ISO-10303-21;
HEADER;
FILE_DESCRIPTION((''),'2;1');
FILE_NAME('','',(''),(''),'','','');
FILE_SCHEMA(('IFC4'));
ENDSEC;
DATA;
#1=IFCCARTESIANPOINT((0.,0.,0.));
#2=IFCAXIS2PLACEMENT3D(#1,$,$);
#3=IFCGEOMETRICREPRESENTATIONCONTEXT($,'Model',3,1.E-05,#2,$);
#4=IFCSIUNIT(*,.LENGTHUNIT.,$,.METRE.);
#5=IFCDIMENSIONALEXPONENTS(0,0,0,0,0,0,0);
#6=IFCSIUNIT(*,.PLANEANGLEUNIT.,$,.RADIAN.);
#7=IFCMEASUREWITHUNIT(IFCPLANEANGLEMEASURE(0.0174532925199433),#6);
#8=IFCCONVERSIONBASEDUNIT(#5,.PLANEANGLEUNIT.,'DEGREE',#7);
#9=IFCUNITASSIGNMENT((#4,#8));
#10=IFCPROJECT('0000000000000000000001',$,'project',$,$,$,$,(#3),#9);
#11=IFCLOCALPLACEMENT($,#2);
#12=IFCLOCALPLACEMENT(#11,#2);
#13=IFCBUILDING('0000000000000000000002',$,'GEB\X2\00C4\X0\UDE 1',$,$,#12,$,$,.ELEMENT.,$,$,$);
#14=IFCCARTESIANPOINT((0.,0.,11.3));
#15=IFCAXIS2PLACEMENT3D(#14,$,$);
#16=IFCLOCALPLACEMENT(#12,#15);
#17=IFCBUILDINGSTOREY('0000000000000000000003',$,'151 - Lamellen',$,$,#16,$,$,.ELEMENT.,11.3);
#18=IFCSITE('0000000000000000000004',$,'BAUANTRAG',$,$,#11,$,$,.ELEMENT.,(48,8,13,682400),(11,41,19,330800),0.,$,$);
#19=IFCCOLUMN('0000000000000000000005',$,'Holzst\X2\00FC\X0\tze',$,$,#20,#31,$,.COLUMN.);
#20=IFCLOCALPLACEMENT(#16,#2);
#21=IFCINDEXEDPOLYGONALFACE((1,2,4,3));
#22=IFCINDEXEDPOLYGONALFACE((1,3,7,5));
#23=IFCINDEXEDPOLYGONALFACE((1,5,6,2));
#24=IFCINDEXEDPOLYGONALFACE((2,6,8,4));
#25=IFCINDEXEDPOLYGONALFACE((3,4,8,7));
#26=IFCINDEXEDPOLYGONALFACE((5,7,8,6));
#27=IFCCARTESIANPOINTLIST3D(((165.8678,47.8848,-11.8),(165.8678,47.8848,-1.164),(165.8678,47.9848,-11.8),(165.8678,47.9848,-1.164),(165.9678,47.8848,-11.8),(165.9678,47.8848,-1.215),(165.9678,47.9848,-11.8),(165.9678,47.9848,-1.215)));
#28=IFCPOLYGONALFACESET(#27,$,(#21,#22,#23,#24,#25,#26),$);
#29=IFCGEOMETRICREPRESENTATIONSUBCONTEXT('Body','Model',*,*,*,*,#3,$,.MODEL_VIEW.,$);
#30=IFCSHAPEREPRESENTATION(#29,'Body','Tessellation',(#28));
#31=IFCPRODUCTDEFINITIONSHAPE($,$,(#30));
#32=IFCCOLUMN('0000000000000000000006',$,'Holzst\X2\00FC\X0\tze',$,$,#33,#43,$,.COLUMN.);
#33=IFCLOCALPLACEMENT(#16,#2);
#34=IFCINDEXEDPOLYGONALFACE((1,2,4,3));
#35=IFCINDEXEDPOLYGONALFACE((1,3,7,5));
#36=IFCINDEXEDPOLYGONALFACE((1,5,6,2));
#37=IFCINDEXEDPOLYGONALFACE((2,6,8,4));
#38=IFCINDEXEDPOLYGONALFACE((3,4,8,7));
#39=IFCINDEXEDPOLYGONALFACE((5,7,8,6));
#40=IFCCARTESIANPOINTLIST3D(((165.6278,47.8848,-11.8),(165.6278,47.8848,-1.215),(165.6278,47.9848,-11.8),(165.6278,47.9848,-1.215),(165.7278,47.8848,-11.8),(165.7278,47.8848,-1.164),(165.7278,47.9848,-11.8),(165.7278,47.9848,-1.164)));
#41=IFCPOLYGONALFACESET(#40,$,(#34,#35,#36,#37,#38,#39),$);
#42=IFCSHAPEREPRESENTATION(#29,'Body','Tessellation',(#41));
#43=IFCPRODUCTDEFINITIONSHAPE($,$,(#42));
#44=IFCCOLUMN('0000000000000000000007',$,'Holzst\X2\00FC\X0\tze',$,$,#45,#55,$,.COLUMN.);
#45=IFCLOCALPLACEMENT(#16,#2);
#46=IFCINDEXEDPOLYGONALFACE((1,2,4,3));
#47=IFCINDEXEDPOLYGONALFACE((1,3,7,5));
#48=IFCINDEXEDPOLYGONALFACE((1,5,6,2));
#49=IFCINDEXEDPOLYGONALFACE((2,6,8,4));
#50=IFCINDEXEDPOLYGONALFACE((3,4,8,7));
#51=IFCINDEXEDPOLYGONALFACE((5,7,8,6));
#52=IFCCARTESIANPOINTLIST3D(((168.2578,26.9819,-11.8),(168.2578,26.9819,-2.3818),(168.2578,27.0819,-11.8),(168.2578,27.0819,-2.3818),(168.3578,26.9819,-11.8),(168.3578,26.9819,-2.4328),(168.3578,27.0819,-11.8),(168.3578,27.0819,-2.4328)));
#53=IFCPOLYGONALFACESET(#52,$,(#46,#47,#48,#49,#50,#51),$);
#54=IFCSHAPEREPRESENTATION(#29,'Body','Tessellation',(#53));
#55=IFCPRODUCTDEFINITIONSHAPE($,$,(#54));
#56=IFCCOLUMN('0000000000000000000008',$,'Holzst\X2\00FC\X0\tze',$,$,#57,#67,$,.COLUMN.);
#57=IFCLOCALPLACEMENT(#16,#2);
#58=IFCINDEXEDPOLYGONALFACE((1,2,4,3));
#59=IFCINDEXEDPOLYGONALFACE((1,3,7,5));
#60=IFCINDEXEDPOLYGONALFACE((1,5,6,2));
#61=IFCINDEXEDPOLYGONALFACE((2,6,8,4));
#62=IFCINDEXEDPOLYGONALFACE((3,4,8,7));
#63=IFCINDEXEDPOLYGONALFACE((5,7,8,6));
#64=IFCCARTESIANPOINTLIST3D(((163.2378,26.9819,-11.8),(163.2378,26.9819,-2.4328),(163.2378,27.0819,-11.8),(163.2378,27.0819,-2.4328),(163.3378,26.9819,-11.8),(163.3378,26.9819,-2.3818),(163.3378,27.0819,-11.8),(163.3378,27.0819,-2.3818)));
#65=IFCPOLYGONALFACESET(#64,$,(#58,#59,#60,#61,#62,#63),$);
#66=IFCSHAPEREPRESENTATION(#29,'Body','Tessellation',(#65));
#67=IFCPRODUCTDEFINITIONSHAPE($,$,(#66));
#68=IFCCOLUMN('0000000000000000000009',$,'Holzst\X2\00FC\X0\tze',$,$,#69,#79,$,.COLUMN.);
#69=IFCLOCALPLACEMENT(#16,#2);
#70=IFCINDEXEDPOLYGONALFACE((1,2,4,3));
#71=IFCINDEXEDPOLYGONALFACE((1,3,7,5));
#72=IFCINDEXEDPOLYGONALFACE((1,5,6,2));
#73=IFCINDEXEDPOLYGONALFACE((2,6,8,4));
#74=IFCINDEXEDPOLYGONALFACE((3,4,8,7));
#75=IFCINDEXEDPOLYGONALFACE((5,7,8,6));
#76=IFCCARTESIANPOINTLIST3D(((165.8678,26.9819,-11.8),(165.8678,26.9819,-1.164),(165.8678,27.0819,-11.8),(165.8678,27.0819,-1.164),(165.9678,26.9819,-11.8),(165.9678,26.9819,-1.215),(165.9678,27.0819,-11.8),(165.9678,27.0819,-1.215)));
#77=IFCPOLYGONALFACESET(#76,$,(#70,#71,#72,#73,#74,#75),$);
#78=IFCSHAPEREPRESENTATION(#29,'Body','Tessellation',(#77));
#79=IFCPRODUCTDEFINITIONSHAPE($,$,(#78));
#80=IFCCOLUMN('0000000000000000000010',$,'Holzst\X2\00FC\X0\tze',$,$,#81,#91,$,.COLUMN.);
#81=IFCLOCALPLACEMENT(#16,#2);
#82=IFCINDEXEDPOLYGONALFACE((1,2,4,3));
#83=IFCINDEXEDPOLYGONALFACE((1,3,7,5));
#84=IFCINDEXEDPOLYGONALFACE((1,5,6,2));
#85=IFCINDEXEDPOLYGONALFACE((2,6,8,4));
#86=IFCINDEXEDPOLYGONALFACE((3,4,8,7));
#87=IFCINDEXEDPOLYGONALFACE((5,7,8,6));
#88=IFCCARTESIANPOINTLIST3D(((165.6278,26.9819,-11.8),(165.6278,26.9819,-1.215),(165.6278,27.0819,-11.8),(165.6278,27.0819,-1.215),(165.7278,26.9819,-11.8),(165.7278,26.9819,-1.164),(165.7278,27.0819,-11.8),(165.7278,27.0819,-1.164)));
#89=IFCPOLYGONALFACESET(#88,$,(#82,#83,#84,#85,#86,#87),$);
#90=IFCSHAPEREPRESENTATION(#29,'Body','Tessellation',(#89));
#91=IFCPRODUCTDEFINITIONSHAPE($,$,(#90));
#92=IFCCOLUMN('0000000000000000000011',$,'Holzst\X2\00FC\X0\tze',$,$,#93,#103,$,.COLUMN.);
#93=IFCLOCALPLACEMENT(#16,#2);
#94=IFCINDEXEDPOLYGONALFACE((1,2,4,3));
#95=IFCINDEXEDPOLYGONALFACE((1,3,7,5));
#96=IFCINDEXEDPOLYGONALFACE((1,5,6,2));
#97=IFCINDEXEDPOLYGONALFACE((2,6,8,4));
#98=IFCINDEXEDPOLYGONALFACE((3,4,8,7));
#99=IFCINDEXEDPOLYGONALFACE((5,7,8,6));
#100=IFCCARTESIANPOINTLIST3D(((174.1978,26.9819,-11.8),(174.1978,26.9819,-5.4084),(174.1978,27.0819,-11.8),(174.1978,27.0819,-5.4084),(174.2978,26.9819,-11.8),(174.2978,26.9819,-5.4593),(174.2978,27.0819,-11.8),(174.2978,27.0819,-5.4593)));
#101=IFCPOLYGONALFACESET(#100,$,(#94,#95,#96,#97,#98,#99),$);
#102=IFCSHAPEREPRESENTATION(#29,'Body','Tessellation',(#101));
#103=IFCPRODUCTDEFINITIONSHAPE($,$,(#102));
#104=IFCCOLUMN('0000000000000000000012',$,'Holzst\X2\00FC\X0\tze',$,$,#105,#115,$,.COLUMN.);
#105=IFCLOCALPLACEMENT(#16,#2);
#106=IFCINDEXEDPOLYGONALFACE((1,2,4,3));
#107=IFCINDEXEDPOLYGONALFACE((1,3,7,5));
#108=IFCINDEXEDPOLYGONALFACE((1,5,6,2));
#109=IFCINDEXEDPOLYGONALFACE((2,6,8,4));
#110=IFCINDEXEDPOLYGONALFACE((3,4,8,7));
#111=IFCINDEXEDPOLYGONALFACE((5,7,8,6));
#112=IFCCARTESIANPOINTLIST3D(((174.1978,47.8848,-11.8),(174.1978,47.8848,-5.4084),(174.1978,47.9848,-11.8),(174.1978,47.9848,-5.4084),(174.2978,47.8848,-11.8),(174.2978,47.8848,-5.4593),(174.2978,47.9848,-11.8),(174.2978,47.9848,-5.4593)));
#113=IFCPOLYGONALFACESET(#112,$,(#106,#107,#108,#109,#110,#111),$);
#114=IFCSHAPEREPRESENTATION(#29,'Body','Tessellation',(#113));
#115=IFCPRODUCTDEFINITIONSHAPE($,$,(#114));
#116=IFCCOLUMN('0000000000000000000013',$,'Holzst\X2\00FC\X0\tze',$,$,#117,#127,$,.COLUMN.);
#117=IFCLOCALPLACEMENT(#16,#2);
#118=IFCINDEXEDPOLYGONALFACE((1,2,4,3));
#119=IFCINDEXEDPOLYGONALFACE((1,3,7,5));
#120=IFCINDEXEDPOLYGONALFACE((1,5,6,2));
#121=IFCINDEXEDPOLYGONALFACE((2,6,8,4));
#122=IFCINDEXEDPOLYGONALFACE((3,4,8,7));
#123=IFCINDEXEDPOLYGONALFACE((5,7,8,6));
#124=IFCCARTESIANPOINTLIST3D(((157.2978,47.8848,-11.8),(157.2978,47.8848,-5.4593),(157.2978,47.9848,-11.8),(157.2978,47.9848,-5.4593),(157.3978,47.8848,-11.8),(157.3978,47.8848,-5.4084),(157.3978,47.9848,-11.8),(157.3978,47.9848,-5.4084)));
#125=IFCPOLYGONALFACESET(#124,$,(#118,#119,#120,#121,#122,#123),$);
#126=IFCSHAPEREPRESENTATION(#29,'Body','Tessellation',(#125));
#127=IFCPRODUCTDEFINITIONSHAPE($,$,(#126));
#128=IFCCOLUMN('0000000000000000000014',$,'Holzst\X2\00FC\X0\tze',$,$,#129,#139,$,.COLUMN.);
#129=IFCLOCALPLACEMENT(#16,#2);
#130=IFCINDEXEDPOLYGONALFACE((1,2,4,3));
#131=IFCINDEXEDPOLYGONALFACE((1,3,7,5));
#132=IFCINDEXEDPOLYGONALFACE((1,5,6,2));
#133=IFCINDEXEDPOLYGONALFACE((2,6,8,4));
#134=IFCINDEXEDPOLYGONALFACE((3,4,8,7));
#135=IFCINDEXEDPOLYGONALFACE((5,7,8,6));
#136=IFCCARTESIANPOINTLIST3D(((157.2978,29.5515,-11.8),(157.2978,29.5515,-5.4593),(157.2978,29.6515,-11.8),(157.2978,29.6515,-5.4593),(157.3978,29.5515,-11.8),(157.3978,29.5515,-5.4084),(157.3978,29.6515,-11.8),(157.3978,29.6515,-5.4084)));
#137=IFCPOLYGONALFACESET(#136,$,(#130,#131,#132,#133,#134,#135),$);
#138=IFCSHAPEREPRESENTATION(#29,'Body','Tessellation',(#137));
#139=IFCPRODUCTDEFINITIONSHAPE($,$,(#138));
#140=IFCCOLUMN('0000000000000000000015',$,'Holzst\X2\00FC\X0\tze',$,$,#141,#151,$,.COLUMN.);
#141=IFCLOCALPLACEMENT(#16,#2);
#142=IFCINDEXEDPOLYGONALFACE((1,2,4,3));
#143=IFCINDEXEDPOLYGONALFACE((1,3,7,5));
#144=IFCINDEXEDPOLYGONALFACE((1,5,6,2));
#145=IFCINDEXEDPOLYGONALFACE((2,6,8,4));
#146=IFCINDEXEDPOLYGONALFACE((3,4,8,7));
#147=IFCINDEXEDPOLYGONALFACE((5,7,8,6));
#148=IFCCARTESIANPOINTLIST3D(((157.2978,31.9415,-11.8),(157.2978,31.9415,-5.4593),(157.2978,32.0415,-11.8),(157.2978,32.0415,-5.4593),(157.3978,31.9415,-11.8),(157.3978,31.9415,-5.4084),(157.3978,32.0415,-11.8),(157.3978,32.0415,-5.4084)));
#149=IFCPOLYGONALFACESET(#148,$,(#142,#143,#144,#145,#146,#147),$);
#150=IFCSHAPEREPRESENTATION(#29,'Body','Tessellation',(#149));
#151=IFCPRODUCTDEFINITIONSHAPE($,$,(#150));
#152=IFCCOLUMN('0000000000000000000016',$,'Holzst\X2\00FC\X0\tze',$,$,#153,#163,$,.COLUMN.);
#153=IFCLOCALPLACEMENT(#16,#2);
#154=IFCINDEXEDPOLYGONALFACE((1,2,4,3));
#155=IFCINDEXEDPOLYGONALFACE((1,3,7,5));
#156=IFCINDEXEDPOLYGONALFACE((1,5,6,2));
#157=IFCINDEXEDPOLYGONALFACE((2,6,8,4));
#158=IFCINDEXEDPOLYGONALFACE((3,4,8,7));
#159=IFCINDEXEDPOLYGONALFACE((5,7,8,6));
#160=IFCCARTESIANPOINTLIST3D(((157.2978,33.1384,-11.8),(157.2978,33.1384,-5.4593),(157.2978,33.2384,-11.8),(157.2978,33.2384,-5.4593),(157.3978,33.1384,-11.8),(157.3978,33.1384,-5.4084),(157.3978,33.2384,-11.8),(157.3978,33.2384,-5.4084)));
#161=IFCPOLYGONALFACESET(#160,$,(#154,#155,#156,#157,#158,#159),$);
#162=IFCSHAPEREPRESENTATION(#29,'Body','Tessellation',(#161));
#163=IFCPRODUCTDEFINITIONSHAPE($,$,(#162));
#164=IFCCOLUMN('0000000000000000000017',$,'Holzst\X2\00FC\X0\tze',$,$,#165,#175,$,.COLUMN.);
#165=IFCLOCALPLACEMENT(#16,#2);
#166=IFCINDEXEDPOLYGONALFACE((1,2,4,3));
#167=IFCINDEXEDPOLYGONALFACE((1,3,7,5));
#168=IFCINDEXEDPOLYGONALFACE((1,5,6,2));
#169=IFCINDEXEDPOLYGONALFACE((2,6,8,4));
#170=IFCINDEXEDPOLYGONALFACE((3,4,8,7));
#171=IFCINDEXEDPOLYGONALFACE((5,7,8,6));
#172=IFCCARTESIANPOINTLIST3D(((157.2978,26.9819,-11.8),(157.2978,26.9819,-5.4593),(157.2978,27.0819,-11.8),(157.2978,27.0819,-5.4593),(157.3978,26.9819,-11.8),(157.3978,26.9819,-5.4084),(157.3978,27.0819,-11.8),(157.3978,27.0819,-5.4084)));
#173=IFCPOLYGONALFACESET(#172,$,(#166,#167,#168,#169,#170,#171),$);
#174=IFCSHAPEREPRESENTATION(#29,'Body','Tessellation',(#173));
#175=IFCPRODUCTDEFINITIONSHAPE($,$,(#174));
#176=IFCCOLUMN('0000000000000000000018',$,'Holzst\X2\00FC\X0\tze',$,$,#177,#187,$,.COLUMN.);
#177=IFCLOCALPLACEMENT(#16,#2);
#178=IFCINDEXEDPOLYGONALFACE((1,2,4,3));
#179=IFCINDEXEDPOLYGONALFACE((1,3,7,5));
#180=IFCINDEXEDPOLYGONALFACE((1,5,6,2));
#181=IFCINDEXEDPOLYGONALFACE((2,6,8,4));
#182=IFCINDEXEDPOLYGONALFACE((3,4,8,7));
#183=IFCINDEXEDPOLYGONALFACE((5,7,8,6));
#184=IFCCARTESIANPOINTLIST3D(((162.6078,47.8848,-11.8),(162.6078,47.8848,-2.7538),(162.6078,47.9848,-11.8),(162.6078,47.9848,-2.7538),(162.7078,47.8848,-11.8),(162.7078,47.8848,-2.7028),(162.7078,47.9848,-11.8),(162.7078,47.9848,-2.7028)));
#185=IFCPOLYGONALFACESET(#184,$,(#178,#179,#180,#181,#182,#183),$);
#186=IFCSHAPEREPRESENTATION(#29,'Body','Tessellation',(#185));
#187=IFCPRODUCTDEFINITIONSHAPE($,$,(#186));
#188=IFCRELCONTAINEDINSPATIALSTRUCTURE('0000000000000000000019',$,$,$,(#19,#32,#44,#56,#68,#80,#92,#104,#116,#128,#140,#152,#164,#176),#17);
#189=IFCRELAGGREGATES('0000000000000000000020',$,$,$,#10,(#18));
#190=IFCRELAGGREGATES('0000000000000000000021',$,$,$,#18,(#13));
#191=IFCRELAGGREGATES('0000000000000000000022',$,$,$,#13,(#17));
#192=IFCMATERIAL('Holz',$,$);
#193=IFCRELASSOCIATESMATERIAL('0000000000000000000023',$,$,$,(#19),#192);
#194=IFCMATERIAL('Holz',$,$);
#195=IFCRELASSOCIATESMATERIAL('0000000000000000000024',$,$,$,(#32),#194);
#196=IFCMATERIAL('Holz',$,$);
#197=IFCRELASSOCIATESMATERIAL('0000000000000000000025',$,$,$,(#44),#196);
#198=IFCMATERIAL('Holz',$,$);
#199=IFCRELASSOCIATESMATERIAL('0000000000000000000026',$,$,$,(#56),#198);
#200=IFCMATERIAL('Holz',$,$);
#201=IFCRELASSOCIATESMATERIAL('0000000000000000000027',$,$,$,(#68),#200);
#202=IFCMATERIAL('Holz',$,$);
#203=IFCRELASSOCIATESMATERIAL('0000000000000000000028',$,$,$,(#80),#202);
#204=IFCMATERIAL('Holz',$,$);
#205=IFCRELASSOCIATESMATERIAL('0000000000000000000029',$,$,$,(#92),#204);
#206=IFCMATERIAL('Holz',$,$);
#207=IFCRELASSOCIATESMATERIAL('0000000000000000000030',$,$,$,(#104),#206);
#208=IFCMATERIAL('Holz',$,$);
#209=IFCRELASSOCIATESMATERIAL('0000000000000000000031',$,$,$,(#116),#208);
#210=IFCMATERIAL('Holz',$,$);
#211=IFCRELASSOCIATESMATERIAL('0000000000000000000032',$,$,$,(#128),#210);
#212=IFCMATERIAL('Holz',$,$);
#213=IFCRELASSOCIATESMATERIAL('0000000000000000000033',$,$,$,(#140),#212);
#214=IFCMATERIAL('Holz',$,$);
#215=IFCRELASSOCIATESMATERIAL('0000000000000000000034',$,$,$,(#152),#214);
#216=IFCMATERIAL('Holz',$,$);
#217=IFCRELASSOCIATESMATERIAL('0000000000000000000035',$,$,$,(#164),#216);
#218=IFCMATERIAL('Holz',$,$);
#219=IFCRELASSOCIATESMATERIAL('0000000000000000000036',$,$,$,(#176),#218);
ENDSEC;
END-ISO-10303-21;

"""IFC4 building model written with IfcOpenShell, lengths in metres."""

from ifc_helpers import new_model, entity, si_unit, converted_unit, frame, frame_2d, origin, origin_with_axes, place, context, subcontext, project, spatial, rectangle, extrude, clip, halfspace, material, element, save


model = new_model("IFC4")

# Units and contexts
model_context = context("Model", 3, precision=1e-05, world=origin())
body_context = subcontext(model_context, "Body", "Model", "MODEL_VIEW")
ifc_project = project(units=[si_unit("LENGTHUNIT", "METRE"), converted_unit("PLANEANGLEUNIT", "DEGREE", entity("IfcPlaneAngleMeasure", 0.0174532925199433), si_unit("PLANEANGLEUNIT", "RADIAN"), dimensions=[0, 0, 0, 0, 0, 0, 0])], contexts=[model_context])

# Site, building, storey
site_placement = place(None, origin())
site = spatial("IfcSite", under=ifc_project, at=site_placement, Name="BAUANTRAG", CompositionType="ELEMENT", RefLatitude=(48, 8, 13, 682400), RefLongitude=(11, 41, 19, 330800), RefElevation=0.0)
building_placement = place(site_placement, origin())
building = spatial("IfcBuilding", under=site, at=building_placement, Name="GEBÄUDE 1", CompositionType="ELEMENT")
storey_placement = place(building_placement, frame((0.0, 0.0, 11.3)))
storey = spatial("IfcBuildingStorey", under=building, at=storey_placement, Name="151 - Lamellen", CompositionType="ELEMENT", Elevation=11.3)

# Columns
ifc_material_1 = material(Name="Holz")
column_1_placement = place(storey_placement, frame((165.9678, 47.8848, -11.8)))
element("IfcColumn", 1, at=column_1_placement, inside=storey, material=ifc_material_1, Name="Holzstütze", PredefinedType="COLUMN", context=body_context, shape_type="Clipping", body=[
    clip(extrude(rectangle(XDim=0.1, YDim=0.1, at=frame_2d((-0.05, 0.05), x_axis=(0.0, 1.0))), origin_with_axes(), (0.0, 0.0, 1.0), 10.636), halfspace(frame((-0.05, 0.05, 10.6105), z_axis=(-0.45399, 0.0, -0.891007), x_axis=(0.0, 1.0, 0.0)), True)),
])
ifc_material_2 = material(Name="Holz")
column_2_placement = place(storey_placement, frame((165.7278, 47.8848, -11.8)))
element("IfcColumn", 2, at=column_2_placement, inside=storey, material=ifc_material_2, Name="Holzstütze", PredefinedType="COLUMN", context=body_context, shape_type="Clipping", body=[
    clip(extrude(rectangle(XDim=0.1, YDim=0.1, at=frame_2d((-0.05, 0.05), x_axis=(0.0, 1.0))), origin_with_axes(), (0.0, 0.0, 1.0), 10.636), halfspace(frame((-0.05, 0.05, 10.6105), z_axis=(0.45399, 0.0, -0.891007), x_axis=(0.0, 1.0, 0.0)), True)),
])
ifc_material_3 = material(Name="Holz")
column_3_placement = place(storey_placement, frame((168.3578, 26.9819, -11.8)))
element("IfcColumn", 3, at=column_3_placement, inside=storey, material=ifc_material_3, Name="Holzstütze", PredefinedType="COLUMN", context=body_context, shape_type="Clipping", body=[
    clip(extrude(rectangle(XDim=0.1, YDim=0.1, at=frame_2d((-0.05, 0.05), x_axis=(0.0, 1.0))), origin_with_axes(), (0.0, 0.0, 1.0), 9.4182), halfspace(frame((-0.05, 0.05, 9.3927), z_axis=(-0.45399, 0.0, -0.891007), x_axis=(0.0, -1.0, 0.0)), True)),
])
ifc_material_4 = material(Name="Holz")
column_4_placement = place(storey_placement, frame((163.3378, 26.9819, -11.8)))
element("IfcColumn", 4, at=column_4_placement, inside=storey, material=ifc_material_4, Name="Holzstütze", PredefinedType="COLUMN", context=body_context, shape_type="Clipping", body=[
    clip(extrude(rectangle(XDim=0.1, YDim=0.1, at=frame_2d((-0.05, 0.05), x_axis=(0.0, 1.0))), origin_with_axes(), (0.0, 0.0, 1.0), 9.4182), halfspace(frame((-0.05, 0.05, 9.3927), z_axis=(0.45399, 0.0, -0.891007), x_axis=(0.0, -1.0, 0.0)), True)),
])
ifc_material_5 = material(Name="Holz")
column_5_placement = place(storey_placement, frame((165.9678, 26.9819, -11.8)))
element("IfcColumn", 5, at=column_5_placement, inside=storey, material=ifc_material_5, Name="Holzstütze", PredefinedType="COLUMN", context=body_context, shape_type="Clipping", body=[
    clip(extrude(rectangle(XDim=0.1, YDim=0.1, at=frame_2d((-0.05, 0.05), x_axis=(0.0, 1.0))), origin_with_axes(), (0.0, 0.0, 1.0), 10.636), halfspace(frame((-0.05, 0.05, 10.6105), z_axis=(-0.45399, 0.0, -0.891007), x_axis=(0.0, -1.0, 0.0)), True)),
])
ifc_material_6 = material(Name="Holz")
column_6_placement = place(storey_placement, frame((165.7278, 26.9819, -11.8)))
element("IfcColumn", 6, at=column_6_placement, inside=storey, material=ifc_material_6, Name="Holzstütze", PredefinedType="COLUMN", context=body_context, shape_type="Clipping", body=[
    clip(extrude(rectangle(XDim=0.1, YDim=0.1, at=frame_2d((-0.05, 0.05), x_axis=(0.0, 1.0))), origin_with_axes(), (0.0, 0.0, 1.0), 10.636), halfspace(frame((-0.05, 0.05, 10.6105), z_axis=(0.45399, 0.0, -0.891007), x_axis=(0.0, -1.0, 0.0)), True)),
])
ifc_material_7 = material(Name="Holz")
column_7_placement = place(storey_placement, frame((174.2978, 26.9819, -11.8)))
element("IfcColumn", 7, at=column_7_placement, inside=storey, material=ifc_material_7, Name="Holzstütze", PredefinedType="COLUMN", context=body_context, shape_type="Clipping", body=[
    clip(extrude(rectangle(XDim=0.1, YDim=0.1, at=frame_2d((-0.05, 0.05), x_axis=(0.0, 1.0))), origin_with_axes(), (0.0, 0.0, 1.0), 6.3916), halfspace(frame((-0.05, 0.05, 6.3661), z_axis=(-0.45399, 0.0, -0.891007), x_axis=(0.0, -1.0, 0.0)), True)),
])
ifc_material_8 = material(Name="Holz")
column_8_placement = place(storey_placement, frame((174.2978, 47.8848, -11.8)))
element("IfcColumn", 8, at=column_8_placement, inside=storey, material=ifc_material_8, Name="Holzstütze", PredefinedType="COLUMN", context=body_context, shape_type="Clipping", body=[
    clip(extrude(rectangle(XDim=0.1, YDim=0.1, at=frame_2d((-0.05, 0.05), x_axis=(0.0, 1.0))), origin_with_axes(), (0.0, 0.0, 1.0), 6.3916), halfspace(frame((-0.05, 0.05, 6.3661), z_axis=(-0.45399, 0.0, -0.891007), x_axis=(0.891007, 0.0, -0.45399)), True)),
])
ifc_material_9 = material(Name="Holz")
column_9_placement = place(storey_placement, frame((157.3978, 47.8848, -11.8)))
element("IfcColumn", 9, at=column_9_placement, inside=storey, material=ifc_material_9, Name="Holzstütze", PredefinedType="COLUMN", context=body_context, shape_type="Clipping", body=[
    clip(extrude(rectangle(XDim=0.1, YDim=0.1, at=frame_2d((-0.05, 0.05), x_axis=(0.0, 1.0))), origin_with_axes(), (0.0, 0.0, 1.0), 6.3916), halfspace(frame((-0.05, 0.05, 6.3661), z_axis=(0.45399, 0.0, -0.891007), x_axis=(0.0, 1.0, 0.0)), True)),
])
ifc_material_10 = material(Name="Holz")
column_10_placement = place(storey_placement, frame((157.3978, 29.5515, -11.8)))
element("IfcColumn", 10, at=column_10_placement, inside=storey, material=ifc_material_10, Name="Holzstütze", PredefinedType="COLUMN", context=body_context, shape_type="Clipping", body=[
    clip(extrude(rectangle(XDim=0.1, YDim=0.1, at=frame_2d((-0.05, 0.05), x_axis=(0.0, 1.0))), origin_with_axes(), (0.0, 0.0, 1.0), 6.3916), halfspace(frame((-0.05, 0.05, 6.3661), z_axis=(0.45399, 0.0, -0.891007), x_axis=(-0.891007, 0.0, -0.45399)), True)),
])
ifc_material_11 = material(Name="Holz")
column_11_placement = place(storey_placement, frame((157.3978, 31.9415, -11.8)))
element("IfcColumn", 11, at=column_11_placement, inside=storey, material=ifc_material_11, Name="Holzstütze", PredefinedType="COLUMN", context=body_context, shape_type="Clipping", body=[
    clip(extrude(rectangle(XDim=0.1, YDim=0.1, at=frame_2d((-0.05, 0.05), x_axis=(0.0, 1.0))), origin_with_axes(), (0.0, 0.0, 1.0), 6.3916), halfspace(frame((-0.05, 0.05, 6.3661), z_axis=(0.45399, 0.0, -0.891007), x_axis=(-0.891007, 0.0, -0.45399)), True)),
])
ifc_material_12 = material(Name="Holz")
column_12_placement = place(storey_placement, frame((157.3978, 33.1384, -11.8)))
element("IfcColumn", 12, at=column_12_placement, inside=storey, material=ifc_material_12, Name="Holzstütze", PredefinedType="COLUMN", context=body_context, shape_type="Clipping", body=[
    clip(extrude(rectangle(XDim=0.1, YDim=0.1, at=frame_2d((-0.05, 0.05), x_axis=(0.0, 1.0))), origin_with_axes(), (0.0, 0.0, 1.0), 6.3916), halfspace(frame((-0.05, 0.05, 6.3661), z_axis=(0.45399, 0.0, -0.891007), x_axis=(-0.891007, 0.0, -0.45399)), True)),
])
ifc_material_13 = material(Name="Holz")
column_13_placement = place(storey_placement, frame((157.3978, 26.9819, -11.8)))
element("IfcColumn", 13, at=column_13_placement, inside=storey, material=ifc_material_13, Name="Holzstütze", PredefinedType="COLUMN", context=body_context, shape_type="Clipping", body=[
    clip(extrude(rectangle(XDim=0.1, YDim=0.1, at=frame_2d((-0.05, 0.05), x_axis=(0.0, 1.0))), origin_with_axes(), (0.0, 0.0, 1.0), 6.3916), halfspace(frame((-0.05, 0.05, 6.3661), z_axis=(0.45399, 0.0, -0.891007), x_axis=(-0.891007, 0.0, -0.45399)), True)),
])
ifc_material_14 = material(Name="Holz")
column_14_placement = place(storey_placement, frame((162.7078, 47.8848, -11.8)))
element("IfcColumn", 14, at=column_14_placement, inside=storey, material=ifc_material_14, Name="Holzstütze", PredefinedType="COLUMN", context=body_context, shape_type="Clipping", body=[
    clip(extrude(rectangle(XDim=0.1, YDim=0.1, at=frame_2d((-0.05, 0.05), x_axis=(0.0, 1.0))), origin_with_axes(), (0.0, 0.0, 1.0), 9.0972), halfspace(frame((-0.05, 0.05, 9.0717), z_axis=(0.45399, 0.0, -0.891007), x_axis=(0.0, 1.0, 0.0)), True)),
])

save(model, "model.ifc")
